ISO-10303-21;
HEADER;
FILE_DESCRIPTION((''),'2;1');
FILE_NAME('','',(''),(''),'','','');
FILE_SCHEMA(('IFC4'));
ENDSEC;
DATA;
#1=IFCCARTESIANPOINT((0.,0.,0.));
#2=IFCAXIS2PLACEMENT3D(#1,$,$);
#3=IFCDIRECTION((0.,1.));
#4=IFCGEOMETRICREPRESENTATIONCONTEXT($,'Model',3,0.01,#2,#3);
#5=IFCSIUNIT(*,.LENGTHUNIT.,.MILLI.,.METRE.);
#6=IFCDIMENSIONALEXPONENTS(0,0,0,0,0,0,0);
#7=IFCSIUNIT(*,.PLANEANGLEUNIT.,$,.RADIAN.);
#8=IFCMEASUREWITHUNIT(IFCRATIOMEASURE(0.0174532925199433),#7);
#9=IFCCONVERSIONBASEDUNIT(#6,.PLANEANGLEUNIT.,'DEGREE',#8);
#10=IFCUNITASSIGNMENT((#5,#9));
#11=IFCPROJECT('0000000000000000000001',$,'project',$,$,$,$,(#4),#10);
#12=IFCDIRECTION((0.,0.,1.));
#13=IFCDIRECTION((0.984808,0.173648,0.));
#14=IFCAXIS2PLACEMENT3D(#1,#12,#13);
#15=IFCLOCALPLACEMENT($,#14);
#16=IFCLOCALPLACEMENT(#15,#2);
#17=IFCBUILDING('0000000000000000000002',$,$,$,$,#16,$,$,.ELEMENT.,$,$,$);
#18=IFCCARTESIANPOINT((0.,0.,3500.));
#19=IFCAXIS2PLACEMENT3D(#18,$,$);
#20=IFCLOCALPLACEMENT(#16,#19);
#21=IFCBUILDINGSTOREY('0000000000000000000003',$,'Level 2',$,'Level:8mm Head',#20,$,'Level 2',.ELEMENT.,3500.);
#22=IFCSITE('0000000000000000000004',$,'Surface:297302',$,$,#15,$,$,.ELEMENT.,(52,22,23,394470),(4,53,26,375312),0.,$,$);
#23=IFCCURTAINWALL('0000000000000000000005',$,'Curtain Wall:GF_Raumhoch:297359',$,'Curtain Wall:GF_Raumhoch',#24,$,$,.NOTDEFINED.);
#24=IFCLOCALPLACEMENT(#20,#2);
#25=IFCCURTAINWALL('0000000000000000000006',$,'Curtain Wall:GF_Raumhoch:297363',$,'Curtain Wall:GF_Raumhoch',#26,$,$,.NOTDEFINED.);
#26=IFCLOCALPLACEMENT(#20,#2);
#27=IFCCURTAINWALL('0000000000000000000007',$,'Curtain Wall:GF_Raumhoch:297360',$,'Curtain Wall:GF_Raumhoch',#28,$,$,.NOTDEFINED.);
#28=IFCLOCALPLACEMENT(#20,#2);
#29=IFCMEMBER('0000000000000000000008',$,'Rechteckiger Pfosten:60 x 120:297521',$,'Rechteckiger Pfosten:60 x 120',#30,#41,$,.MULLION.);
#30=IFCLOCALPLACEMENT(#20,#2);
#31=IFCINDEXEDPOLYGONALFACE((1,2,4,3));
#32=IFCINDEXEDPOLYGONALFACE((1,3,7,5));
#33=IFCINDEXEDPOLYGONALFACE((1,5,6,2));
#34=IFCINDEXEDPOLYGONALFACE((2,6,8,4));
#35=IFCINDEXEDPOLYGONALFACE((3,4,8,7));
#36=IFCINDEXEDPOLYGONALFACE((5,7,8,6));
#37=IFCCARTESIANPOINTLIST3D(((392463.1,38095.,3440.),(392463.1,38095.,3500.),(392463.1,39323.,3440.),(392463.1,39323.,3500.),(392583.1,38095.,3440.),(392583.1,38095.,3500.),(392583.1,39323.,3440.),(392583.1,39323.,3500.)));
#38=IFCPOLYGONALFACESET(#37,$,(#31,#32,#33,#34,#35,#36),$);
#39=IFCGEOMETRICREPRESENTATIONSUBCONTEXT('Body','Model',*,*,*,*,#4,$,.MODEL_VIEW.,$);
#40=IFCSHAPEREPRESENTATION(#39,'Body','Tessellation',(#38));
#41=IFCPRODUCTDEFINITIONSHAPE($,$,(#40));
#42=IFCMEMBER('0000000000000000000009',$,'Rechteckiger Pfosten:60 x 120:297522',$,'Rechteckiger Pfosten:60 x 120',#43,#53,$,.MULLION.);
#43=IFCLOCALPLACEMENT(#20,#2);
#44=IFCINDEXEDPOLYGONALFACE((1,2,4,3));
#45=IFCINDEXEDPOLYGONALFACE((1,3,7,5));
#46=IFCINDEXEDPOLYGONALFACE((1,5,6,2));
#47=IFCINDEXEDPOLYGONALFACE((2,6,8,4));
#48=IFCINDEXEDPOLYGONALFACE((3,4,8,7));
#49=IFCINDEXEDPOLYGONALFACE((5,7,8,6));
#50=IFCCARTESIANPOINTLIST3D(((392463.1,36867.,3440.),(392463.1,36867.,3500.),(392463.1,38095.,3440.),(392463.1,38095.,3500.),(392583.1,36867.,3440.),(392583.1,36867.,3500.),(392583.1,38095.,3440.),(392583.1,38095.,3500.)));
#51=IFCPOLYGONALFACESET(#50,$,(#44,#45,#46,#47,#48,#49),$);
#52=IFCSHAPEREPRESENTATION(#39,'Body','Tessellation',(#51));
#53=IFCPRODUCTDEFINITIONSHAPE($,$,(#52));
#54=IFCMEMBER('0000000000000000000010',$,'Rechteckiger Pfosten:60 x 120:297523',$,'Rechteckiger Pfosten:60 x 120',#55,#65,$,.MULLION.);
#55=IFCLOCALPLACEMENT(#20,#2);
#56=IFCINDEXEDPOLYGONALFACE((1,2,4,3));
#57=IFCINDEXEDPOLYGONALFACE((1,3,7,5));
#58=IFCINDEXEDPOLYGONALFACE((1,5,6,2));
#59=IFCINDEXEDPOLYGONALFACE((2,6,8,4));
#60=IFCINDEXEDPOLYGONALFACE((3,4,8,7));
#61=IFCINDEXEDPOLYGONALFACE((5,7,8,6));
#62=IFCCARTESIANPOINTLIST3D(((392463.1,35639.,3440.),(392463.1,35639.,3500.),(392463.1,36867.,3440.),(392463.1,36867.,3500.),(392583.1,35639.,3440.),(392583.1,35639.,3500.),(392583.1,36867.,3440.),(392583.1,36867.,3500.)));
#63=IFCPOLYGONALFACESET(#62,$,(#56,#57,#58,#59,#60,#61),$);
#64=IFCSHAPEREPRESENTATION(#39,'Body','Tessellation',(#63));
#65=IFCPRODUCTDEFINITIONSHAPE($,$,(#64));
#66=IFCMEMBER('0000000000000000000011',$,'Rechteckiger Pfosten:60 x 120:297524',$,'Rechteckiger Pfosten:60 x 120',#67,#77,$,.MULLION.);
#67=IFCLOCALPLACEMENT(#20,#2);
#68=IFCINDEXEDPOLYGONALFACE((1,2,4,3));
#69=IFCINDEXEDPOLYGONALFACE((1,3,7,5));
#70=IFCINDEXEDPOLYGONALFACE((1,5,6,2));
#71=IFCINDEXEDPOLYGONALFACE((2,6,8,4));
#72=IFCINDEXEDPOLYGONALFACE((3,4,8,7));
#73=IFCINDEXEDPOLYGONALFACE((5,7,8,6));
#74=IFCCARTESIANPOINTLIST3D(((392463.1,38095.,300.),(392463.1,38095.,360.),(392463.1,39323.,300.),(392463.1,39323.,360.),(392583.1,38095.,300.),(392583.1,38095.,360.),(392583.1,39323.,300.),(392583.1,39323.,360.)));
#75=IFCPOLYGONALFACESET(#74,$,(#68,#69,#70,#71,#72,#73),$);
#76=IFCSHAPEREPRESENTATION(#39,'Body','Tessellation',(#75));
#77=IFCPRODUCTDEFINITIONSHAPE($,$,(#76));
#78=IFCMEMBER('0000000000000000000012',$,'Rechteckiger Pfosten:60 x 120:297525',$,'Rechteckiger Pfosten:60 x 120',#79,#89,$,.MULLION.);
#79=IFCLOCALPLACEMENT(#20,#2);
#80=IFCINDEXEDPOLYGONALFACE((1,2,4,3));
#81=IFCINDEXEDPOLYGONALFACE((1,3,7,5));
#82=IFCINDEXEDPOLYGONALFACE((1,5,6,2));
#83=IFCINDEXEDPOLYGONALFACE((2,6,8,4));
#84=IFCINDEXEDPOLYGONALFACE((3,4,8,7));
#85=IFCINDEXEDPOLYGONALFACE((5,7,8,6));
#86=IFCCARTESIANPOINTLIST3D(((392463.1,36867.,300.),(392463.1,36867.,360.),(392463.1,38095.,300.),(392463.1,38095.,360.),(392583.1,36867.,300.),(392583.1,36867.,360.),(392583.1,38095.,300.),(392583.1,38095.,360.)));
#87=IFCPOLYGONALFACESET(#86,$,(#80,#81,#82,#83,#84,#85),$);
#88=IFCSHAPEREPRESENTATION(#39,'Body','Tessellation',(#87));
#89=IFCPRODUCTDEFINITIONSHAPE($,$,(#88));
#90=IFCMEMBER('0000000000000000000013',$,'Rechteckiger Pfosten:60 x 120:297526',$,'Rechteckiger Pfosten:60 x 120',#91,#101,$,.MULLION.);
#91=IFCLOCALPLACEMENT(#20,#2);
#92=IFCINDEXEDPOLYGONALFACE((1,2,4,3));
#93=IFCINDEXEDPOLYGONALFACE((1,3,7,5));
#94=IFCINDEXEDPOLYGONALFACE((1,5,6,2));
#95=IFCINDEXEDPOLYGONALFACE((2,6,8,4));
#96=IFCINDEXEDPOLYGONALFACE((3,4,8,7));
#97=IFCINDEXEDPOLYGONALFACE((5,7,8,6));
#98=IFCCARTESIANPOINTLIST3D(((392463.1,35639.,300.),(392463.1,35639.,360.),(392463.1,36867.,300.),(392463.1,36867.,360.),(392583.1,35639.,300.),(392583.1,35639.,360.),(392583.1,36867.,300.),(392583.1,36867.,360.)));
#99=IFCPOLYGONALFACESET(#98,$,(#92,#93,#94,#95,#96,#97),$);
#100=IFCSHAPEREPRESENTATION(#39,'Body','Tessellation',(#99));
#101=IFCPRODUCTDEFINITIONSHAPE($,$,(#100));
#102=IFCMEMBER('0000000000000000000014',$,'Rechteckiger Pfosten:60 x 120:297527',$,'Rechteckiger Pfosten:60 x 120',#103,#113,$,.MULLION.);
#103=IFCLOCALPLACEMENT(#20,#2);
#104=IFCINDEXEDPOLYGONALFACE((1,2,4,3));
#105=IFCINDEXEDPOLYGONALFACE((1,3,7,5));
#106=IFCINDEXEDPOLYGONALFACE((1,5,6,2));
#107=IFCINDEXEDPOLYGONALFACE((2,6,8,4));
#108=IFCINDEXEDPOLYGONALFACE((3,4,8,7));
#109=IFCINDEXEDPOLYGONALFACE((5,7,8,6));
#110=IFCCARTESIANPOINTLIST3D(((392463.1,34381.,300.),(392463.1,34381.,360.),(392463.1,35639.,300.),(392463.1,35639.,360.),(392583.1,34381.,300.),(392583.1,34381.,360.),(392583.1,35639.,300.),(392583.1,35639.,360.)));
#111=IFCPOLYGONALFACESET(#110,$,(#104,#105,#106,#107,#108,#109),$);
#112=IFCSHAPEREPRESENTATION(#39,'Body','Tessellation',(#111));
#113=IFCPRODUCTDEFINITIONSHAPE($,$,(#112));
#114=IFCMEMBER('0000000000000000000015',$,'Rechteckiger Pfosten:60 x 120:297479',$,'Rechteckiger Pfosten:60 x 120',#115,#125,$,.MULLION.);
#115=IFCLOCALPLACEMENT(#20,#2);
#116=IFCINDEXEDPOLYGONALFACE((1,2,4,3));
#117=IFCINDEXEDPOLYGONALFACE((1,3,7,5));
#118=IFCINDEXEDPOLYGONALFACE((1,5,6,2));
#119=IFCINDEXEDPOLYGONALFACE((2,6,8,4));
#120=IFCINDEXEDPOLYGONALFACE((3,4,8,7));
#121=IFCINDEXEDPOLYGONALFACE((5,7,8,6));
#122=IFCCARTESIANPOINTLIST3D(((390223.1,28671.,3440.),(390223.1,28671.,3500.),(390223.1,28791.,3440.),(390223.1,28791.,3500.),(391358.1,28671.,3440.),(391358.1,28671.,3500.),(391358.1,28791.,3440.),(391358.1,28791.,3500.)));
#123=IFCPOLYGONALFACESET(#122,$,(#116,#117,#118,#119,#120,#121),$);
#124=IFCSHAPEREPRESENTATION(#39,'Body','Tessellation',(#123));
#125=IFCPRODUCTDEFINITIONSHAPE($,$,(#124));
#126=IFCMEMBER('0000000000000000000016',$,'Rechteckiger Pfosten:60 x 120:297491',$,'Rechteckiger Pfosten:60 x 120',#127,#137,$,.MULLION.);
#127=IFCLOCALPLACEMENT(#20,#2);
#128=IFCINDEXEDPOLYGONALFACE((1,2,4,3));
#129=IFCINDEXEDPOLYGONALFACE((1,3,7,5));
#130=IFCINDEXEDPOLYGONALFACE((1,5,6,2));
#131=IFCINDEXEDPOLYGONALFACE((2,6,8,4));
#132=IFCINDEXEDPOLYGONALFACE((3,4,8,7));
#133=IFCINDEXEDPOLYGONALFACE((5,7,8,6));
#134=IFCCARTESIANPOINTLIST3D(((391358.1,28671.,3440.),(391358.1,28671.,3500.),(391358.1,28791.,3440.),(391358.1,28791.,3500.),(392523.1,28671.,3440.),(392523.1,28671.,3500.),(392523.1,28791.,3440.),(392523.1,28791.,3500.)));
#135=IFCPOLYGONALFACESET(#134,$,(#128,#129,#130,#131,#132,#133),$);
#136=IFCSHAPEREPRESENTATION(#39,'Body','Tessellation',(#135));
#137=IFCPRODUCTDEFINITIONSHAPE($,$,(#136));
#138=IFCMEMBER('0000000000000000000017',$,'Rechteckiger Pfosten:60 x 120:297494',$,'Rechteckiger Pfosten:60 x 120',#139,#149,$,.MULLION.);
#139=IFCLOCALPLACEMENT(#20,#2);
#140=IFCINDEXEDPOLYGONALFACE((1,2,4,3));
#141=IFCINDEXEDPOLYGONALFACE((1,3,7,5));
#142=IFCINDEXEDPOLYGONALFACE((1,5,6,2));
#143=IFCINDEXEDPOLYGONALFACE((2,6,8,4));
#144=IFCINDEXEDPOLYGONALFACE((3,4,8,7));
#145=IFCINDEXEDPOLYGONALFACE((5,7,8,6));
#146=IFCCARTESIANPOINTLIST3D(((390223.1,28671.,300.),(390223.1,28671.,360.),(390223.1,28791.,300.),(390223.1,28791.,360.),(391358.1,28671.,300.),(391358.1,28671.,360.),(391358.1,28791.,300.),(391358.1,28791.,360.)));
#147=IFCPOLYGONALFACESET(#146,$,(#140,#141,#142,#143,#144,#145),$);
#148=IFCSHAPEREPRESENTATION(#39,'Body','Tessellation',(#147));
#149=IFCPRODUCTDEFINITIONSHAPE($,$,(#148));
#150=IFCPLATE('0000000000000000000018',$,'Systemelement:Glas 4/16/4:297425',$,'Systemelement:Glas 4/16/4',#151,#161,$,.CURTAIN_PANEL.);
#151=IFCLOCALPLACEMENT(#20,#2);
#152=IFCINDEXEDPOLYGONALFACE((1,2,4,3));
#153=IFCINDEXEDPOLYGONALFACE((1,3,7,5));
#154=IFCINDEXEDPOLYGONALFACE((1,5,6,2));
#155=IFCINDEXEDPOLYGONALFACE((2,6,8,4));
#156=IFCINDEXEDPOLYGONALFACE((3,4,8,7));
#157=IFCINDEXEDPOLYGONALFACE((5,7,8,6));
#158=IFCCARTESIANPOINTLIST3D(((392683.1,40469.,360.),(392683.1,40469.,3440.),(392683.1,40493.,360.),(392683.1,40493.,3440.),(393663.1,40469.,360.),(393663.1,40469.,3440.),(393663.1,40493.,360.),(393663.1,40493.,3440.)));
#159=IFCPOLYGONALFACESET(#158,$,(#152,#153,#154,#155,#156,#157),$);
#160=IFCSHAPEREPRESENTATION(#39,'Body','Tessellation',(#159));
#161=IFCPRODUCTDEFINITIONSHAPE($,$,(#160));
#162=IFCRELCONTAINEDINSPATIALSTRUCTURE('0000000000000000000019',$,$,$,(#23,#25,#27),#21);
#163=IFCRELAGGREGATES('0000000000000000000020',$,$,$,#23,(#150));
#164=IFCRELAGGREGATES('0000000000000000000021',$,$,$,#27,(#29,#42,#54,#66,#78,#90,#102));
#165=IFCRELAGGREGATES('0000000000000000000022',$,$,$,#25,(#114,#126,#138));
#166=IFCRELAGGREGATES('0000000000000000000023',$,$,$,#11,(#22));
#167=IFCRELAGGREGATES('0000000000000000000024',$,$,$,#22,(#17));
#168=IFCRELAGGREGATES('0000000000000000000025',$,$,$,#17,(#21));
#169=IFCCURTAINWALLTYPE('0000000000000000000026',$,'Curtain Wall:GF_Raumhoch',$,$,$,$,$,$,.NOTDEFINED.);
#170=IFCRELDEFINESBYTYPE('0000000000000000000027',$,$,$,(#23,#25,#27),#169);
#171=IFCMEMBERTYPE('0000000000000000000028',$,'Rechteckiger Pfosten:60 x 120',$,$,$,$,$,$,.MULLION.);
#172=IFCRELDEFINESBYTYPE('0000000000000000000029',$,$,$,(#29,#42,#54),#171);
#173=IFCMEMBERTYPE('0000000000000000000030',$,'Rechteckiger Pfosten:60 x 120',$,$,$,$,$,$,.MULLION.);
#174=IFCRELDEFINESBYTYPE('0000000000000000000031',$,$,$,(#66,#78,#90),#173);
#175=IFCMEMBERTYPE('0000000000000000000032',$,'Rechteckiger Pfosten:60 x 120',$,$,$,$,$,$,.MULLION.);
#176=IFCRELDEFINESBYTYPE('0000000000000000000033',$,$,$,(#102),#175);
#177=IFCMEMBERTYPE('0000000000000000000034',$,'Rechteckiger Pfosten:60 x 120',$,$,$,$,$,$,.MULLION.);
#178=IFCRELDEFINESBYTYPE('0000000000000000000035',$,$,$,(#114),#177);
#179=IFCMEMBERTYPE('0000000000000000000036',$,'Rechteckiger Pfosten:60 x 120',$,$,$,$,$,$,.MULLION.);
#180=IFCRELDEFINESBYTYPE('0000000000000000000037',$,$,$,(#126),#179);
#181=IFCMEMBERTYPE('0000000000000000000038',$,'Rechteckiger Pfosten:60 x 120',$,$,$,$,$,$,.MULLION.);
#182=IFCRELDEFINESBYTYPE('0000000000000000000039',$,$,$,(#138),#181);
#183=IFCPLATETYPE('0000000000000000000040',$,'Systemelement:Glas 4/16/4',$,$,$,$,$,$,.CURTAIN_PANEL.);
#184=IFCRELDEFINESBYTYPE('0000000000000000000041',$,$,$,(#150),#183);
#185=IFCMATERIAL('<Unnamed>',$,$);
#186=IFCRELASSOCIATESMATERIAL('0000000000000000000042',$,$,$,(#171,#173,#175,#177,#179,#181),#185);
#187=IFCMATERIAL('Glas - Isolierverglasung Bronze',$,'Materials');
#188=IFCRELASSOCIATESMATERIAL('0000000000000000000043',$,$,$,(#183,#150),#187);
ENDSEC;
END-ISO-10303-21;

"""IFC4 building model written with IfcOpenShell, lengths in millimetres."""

from ifc_helpers import new_model, entity, si_unit, converted_unit, direction, frame, origin, place, context, subcontext, project, spatial, indexed_curve, outline, extrude, source, transform, mapped, material, type_object, type_shapes, element, aggregate, save


model = new_model("IFC4")

# Units and contexts
model_context = context("Model", 3, precision=0.01, world=origin(), true_north=direction((0.0, 1.0)))
body_context = subcontext(model_context, "Body", "Model", "MODEL_VIEW")
ifc_project = project(units=[si_unit("LENGTHUNIT", "METRE", prefix="MILLI"), converted_unit("PLANEANGLEUNIT", "DEGREE", entity("IfcRatioMeasure", 0.0174532925199433), si_unit("PLANEANGLEUNIT", "RADIAN"), dimensions=[0, 0, 0, 0, 0, 0, 0])], contexts=[model_context])

# Site, building, storey
site_placement = place(None, frame((0.0, 0.0, 0.0), z_axis=(0.0, 0.0, 1.0), x_axis=(0.984808, 0.173648, 0.0)))
site = spatial("IfcSite", under=ifc_project, at=site_placement, Name="Surface:297302", CompositionType="ELEMENT", RefLatitude=(52, 22, 23, 394470), RefLongitude=(4, 53, 26, 375312), RefElevation=0.0)
building_placement = place(site_placement, origin())
building = spatial("IfcBuilding", under=site, at=building_placement, CompositionType="ELEMENT")
storey_placement = place(building_placement, frame((0.0, 0.0, 3500.0)))
storey = spatial("IfcBuildingStorey", under=building, at=storey_placement, Name="Level 2", ObjectType="Level:8mm Head", LongName="Level 2", CompositionType="ELEMENT", Elevation=3500.0)

# Curtain wall
curtain_wall_type = type_object("IfcCurtainWallType", Name="Curtain Wall:GF_Raumhoch", PredefinedType="NOTDEFINED")
curtain_wall_1_placement = place(storey_placement, frame((0.0, 0.0, -3500.0)))
curtain_wall_1 = element("IfcCurtainWall", 1, at=curtain_wall_1_placement, inside=storey, type_object=curtain_wall_type, Name="Curtain Wall:GF_Raumhoch:297359", ObjectType="Curtain Wall:GF_Raumhoch", PredefinedType="NOTDEFINED")
ifc_material_1 = material(Name="<Unnamed>")

# Curtain wall
curtain_wall_2_placement = place(storey_placement, frame((0.0, 0.0, -3500.0)))
curtain_wall_2 = element("IfcCurtainWall", 2, at=curtain_wall_2_placement, inside=storey, type_object=curtain_wall_type, Name="Curtain Wall:GF_Raumhoch:297363", ObjectType="Curtain Wall:GF_Raumhoch", PredefinedType="NOTDEFINED")

# Curtain wall
curtain_wall_3_placement = place(storey_placement, frame((0.0, 0.0, -3500.0)))
curtain_wall_3 = element("IfcCurtainWall", 3, at=curtain_wall_3_placement, inside=storey, type_object=curtain_wall_type, Name="Curtain Wall:GF_Raumhoch:297360", ObjectType="Curtain Wall:GF_Raumhoch", PredefinedType="NOTDEFINED")

# Members
member_type_1 = type_object("IfcMemberType", Name="Rechteckiger Pfosten:60 x 120", PredefinedType="MULLION", material=ifc_material_1)
shared_shape_1 = source(origin(), body_context, "Body", "SweptSolid", [
    extrude(outline(indexed_curve([(-60.0, -30.0), (60.0, -30.0), (60.0, 30.0), (-60.0, 30.0), (-60.0, -30.0)], self_intersect=False)), frame((-30.0, 0.0, -1228.0), z_axis=(0.0, 0.0, 1.0), x_axis=(0.0, -1.0, 0.0)), (0.0, 0.0, 1.0), 1228.0),
])
type_shapes(member_type_1, [shared_shape_1])
member_1_placement = place(curtain_wall_3_placement, frame((392523.1, 38095.0, 7000.0), z_axis=(0.0, -1.0, 0.0), x_axis=(0.0, 0.0, 1.0)))
member_1 = element("IfcMember", 4, at=member_1_placement, type_object=member_type_1, Name="Rechteckiger Pfosten:60 x 120:297521", ObjectType="Rechteckiger Pfosten:60 x 120", PredefinedType="MULLION", context=body_context, shape_type="MappedRepresentation", body=[
    mapped(shared_shape_1, transform((0.0, 0.0, 0.0), scale=1.0)),
])
member_2_placement = place(curtain_wall_3_placement, frame((392523.1, 36867.0, 7000.0), z_axis=(0.0, -1.0, 0.0), x_axis=(0.0, 0.0, 1.0)))
member_2 = element("IfcMember", 5, at=member_2_placement, type_object=member_type_1, Name="Rechteckiger Pfosten:60 x 120:297522", ObjectType="Rechteckiger Pfosten:60 x 120", PredefinedType="MULLION", context=body_context, shape_type="MappedRepresentation", body=[
    mapped(shared_shape_1, transform((0.0, 0.0, 0.0), scale=1.0)),
])
member_3_placement = place(curtain_wall_3_placement, frame((392523.1, 35639.0, 7000.0), z_axis=(0.0, -1.0, 0.0), x_axis=(0.0, 0.0, 1.0)))
member_3 = element("IfcMember", 6, at=member_3_placement, type_object=member_type_1, Name="Rechteckiger Pfosten:60 x 120:297523", ObjectType="Rechteckiger Pfosten:60 x 120", PredefinedType="MULLION", context=body_context, shape_type="MappedRepresentation", body=[
    mapped(shared_shape_1, transform((0.0, 0.0, 0.0), scale=1.0)),
])
member_type_2 = type_object("IfcMemberType", Name="Rechteckiger Pfosten:60 x 120", PredefinedType="MULLION", material=ifc_material_1)
shared_shape_2 = source(origin(), body_context, "Body", "SweptSolid", [
    extrude(outline(indexed_curve([(-60.0, -30.0), (60.0, -30.0), (60.0, 30.0), (-60.0, 30.0), (-60.0, -30.0)], self_intersect=False)), frame((-30.0, 0.0, -1228.0), z_axis=(0.0, 0.0, 1.0), x_axis=(0.0, -1.0, 0.0)), (0.0, 0.0, 1.0), 1228.0),
])
type_shapes(member_type_2, [shared_shape_2])
member_4_placement = place(curtain_wall_3_placement, frame((392523.1, 39323.0, 3800.0), z_axis=(0.0, 1.0, 0.0), x_axis=(0.0, 0.0, -1.0)))
member_4 = element("IfcMember", 7, at=member_4_placement, type_object=member_type_2, Name="Rechteckiger Pfosten:60 x 120:297524", ObjectType="Rechteckiger Pfosten:60 x 120", PredefinedType="MULLION", context=body_context, shape_type="MappedRepresentation", body=[
    mapped(shared_shape_2, transform((0.0, 0.0, 0.0), scale=1.0)),
])
member_5_placement = place(curtain_wall_3_placement, frame((392523.1, 38095.0, 3800.0), z_axis=(0.0, 1.0, 0.0), x_axis=(0.0, 0.0, -1.0)))
member_5 = element("IfcMember", 8, at=member_5_placement, type_object=member_type_2, Name="Rechteckiger Pfosten:60 x 120:297525", ObjectType="Rechteckiger Pfosten:60 x 120", PredefinedType="MULLION", context=body_context, shape_type="MappedRepresentation", body=[
    mapped(shared_shape_2, transform((0.0, 0.0, 0.0), scale=1.0)),
])
member_6_placement = place(curtain_wall_3_placement, frame((392523.1, 36867.0, 3800.0), z_axis=(0.0, 1.0, 0.0), x_axis=(0.0, 0.0, -1.0)))
member_6 = element("IfcMember", 9, at=member_6_placement, type_object=member_type_2, Name="Rechteckiger Pfosten:60 x 120:297526", ObjectType="Rechteckiger Pfosten:60 x 120", PredefinedType="MULLION", context=body_context, shape_type="MappedRepresentation", body=[
    mapped(shared_shape_2, transform((0.0, 0.0, 0.0), scale=1.0)),
])
member_type_3 = type_object("IfcMemberType", Name="Rechteckiger Pfosten:60 x 120", PredefinedType="MULLION", material=ifc_material_1)
shared_shape_3 = source(origin(), body_context, "Body", "SweptSolid", [
    extrude(outline(indexed_curve([(-60.0, -30.0), (60.0, -30.0), (60.0, 30.0), (-60.0, 30.0), (-60.0, -30.0)], self_intersect=False)), frame((-30.0, 0.0, -1258.0), z_axis=(0.0, 0.0, 1.0), x_axis=(0.0, -1.0, 0.0)), (0.0, 0.0, 1.0), 1258.0),
])
type_shapes(member_type_3, [shared_shape_3])
member_7_placement = place(curtain_wall_3_placement, frame((392523.1, 35639.0, 3800.0), z_axis=(0.0, 1.0, 0.0), x_axis=(0.0, 0.0, -1.0)))
member_7 = element("IfcMember", 10, at=member_7_placement, type_object=member_type_3, Name="Rechteckiger Pfosten:60 x 120:297527", ObjectType="Rechteckiger Pfosten:60 x 120", PredefinedType="MULLION", context=body_context, shape_type="MappedRepresentation", body=[
    mapped(shared_shape_3, transform((0.0, 0.0, 0.0), scale=1.0)),
])
member_type_4 = type_object("IfcMemberType", Name="Rechteckiger Pfosten:60 x 120", PredefinedType="MULLION", material=ifc_material_1)
shared_shape_4 = source(origin(), body_context, "Body", "SweptSolid", [
    extrude(outline(indexed_curve([(-60.0, -30.0), (60.0, -30.0), (60.0, 30.0), (-60.0, 30.0), (-60.0, -30.0)], self_intersect=False)), frame((-30.0, 0.0, -1135.0), z_axis=(0.0, 0.0, 1.0), x_axis=(0.0, -1.0, 0.0)), (0.0, 0.0, 1.0), 1135.0),
])
type_shapes(member_type_4, [shared_shape_4])
member_8_placement = place(curtain_wall_2_placement, frame((390223.1, 28731.0, 7000.0), z_axis=(-1.0, 0.0, 0.0), x_axis=(0.0, 0.0, 1.0)))
member_8 = element("IfcMember", 11, at=member_8_placement, type_object=member_type_4, Name="Rechteckiger Pfosten:60 x 120:297479", ObjectType="Rechteckiger Pfosten:60 x 120", PredefinedType="MULLION", context=body_context, shape_type="MappedRepresentation", body=[
    mapped(shared_shape_4, transform((0.0, 0.0, 0.0), scale=1.0)),
])
member_type_5 = type_object("IfcMemberType", Name="Rechteckiger Pfosten:60 x 120", PredefinedType="MULLION", material=ifc_material_1)
shared_shape_5 = source(origin(), body_context, "Body", "SweptSolid", [
    extrude(outline(indexed_curve([(-60.0, -30.0), (60.0, -30.0), (60.0, 30.0), (-60.0, 30.0), (-60.0, -30.0)], self_intersect=False)), frame((-30.0, 0.0, -1165.0), z_axis=(0.0, 0.0, 1.0), x_axis=(0.0, -1.0, 0.0)), (0.0, 0.0, 1.0), 1165.0),
])
type_shapes(member_type_5, [shared_shape_5])
member_9_placement = place(curtain_wall_2_placement, frame((391358.1, 28731.0, 7000.0), z_axis=(-1.0, 0.0, 0.0), x_axis=(0.0, 0.0, 1.0)))
member_9 = element("IfcMember", 12, at=member_9_placement, type_object=member_type_5, Name="Rechteckiger Pfosten:60 x 120:297491", ObjectType="Rechteckiger Pfosten:60 x 120", PredefinedType="MULLION", context=body_context, shape_type="MappedRepresentation", body=[
    mapped(shared_shape_5, transform((0.0, 0.0, 0.0), scale=1.0)),
])
member_type_6 = type_object("IfcMemberType", Name="Rechteckiger Pfosten:60 x 120", PredefinedType="MULLION", material=ifc_material_1)
shared_shape_6 = source(origin(), body_context, "Body", "SweptSolid", [
    extrude(outline(indexed_curve([(-60.0, -30.0), (60.0, -30.0), (60.0, 30.0), (-60.0, 30.0), (-60.0, -30.0)], self_intersect=False)), frame((-30.0, 0.0, -1135.0), z_axis=(0.0, 0.0, 1.0), x_axis=(0.0, -1.0, 0.0)), (0.0, 0.0, 1.0), 1135.0),
])
type_shapes(member_type_6, [shared_shape_6])
member_10_placement = place(curtain_wall_2_placement, frame((391358.1, 28731.0, 3800.0), z_axis=(1.0, 0.0, 0.0), x_axis=(0.0, 0.0, -1.0)))
member_10 = element("IfcMember", 13, at=member_10_placement, type_object=member_type_6, Name="Rechteckiger Pfosten:60 x 120:297494", ObjectType="Rechteckiger Pfosten:60 x 120", PredefinedType="MULLION", context=body_context, shape_type="MappedRepresentation", body=[
    mapped(shared_shape_6, transform((0.0, 0.0, 0.0), scale=1.0)),
])

# Plate
ifc_material_2 = material(Name="Glas - Isolierverglasung Bronze", Category="Materials")
plate_type_1 = type_object("IfcPlateType", Name="Systemelement:Glas 4/16/4", PredefinedType="CURTAIN_PANEL", material=ifc_material_2)
shared_shape_7 = source(origin(), body_context, "Body", "SweptSolid", [
    extrude(outline(indexed_curve([(-12.0, -490.0), (12.0, -490.0), (12.0, 490.0), (-12.0, 490.0), (-12.0, -490.0)], self_intersect=False)), frame((0.0, 0.0, 0.0), z_axis=(0.0, 0.0, 1.0), x_axis=(0.0, 1.0, 0.0)), (0.0, 0.0, 1.0), 3080.0),
])
type_shapes(plate_type_1, [shared_shape_7])
plate_1_placement = place(curtain_wall_1_placement, frame((393173.1, 40481.0, 3860.0), z_axis=(0.0, 0.0, 1.0), x_axis=(-1.0, 0.0, 0.0)))
plate_1 = element("IfcPlate", 14, at=plate_1_placement, type_object=plate_type_1, material=ifc_material_2, Name="Systemelement:Glas 4/16/4:297425", ObjectType="Systemelement:Glas 4/16/4", PredefinedType="CURTAIN_PANEL", context=body_context, shape_type="MappedRepresentation", body=[
    mapped(shared_shape_7, transform((0.0, 0.0, 0.0), scale=1.0)),
])
aggregate(curtain_wall_1, [plate_1])
aggregate(curtain_wall_3, [member_1, member_2, member_3, member_4, member_5, member_6, member_7])
aggregate(curtain_wall_2, [member_8, member_9, member_10])

save(model, "model.ifc")
